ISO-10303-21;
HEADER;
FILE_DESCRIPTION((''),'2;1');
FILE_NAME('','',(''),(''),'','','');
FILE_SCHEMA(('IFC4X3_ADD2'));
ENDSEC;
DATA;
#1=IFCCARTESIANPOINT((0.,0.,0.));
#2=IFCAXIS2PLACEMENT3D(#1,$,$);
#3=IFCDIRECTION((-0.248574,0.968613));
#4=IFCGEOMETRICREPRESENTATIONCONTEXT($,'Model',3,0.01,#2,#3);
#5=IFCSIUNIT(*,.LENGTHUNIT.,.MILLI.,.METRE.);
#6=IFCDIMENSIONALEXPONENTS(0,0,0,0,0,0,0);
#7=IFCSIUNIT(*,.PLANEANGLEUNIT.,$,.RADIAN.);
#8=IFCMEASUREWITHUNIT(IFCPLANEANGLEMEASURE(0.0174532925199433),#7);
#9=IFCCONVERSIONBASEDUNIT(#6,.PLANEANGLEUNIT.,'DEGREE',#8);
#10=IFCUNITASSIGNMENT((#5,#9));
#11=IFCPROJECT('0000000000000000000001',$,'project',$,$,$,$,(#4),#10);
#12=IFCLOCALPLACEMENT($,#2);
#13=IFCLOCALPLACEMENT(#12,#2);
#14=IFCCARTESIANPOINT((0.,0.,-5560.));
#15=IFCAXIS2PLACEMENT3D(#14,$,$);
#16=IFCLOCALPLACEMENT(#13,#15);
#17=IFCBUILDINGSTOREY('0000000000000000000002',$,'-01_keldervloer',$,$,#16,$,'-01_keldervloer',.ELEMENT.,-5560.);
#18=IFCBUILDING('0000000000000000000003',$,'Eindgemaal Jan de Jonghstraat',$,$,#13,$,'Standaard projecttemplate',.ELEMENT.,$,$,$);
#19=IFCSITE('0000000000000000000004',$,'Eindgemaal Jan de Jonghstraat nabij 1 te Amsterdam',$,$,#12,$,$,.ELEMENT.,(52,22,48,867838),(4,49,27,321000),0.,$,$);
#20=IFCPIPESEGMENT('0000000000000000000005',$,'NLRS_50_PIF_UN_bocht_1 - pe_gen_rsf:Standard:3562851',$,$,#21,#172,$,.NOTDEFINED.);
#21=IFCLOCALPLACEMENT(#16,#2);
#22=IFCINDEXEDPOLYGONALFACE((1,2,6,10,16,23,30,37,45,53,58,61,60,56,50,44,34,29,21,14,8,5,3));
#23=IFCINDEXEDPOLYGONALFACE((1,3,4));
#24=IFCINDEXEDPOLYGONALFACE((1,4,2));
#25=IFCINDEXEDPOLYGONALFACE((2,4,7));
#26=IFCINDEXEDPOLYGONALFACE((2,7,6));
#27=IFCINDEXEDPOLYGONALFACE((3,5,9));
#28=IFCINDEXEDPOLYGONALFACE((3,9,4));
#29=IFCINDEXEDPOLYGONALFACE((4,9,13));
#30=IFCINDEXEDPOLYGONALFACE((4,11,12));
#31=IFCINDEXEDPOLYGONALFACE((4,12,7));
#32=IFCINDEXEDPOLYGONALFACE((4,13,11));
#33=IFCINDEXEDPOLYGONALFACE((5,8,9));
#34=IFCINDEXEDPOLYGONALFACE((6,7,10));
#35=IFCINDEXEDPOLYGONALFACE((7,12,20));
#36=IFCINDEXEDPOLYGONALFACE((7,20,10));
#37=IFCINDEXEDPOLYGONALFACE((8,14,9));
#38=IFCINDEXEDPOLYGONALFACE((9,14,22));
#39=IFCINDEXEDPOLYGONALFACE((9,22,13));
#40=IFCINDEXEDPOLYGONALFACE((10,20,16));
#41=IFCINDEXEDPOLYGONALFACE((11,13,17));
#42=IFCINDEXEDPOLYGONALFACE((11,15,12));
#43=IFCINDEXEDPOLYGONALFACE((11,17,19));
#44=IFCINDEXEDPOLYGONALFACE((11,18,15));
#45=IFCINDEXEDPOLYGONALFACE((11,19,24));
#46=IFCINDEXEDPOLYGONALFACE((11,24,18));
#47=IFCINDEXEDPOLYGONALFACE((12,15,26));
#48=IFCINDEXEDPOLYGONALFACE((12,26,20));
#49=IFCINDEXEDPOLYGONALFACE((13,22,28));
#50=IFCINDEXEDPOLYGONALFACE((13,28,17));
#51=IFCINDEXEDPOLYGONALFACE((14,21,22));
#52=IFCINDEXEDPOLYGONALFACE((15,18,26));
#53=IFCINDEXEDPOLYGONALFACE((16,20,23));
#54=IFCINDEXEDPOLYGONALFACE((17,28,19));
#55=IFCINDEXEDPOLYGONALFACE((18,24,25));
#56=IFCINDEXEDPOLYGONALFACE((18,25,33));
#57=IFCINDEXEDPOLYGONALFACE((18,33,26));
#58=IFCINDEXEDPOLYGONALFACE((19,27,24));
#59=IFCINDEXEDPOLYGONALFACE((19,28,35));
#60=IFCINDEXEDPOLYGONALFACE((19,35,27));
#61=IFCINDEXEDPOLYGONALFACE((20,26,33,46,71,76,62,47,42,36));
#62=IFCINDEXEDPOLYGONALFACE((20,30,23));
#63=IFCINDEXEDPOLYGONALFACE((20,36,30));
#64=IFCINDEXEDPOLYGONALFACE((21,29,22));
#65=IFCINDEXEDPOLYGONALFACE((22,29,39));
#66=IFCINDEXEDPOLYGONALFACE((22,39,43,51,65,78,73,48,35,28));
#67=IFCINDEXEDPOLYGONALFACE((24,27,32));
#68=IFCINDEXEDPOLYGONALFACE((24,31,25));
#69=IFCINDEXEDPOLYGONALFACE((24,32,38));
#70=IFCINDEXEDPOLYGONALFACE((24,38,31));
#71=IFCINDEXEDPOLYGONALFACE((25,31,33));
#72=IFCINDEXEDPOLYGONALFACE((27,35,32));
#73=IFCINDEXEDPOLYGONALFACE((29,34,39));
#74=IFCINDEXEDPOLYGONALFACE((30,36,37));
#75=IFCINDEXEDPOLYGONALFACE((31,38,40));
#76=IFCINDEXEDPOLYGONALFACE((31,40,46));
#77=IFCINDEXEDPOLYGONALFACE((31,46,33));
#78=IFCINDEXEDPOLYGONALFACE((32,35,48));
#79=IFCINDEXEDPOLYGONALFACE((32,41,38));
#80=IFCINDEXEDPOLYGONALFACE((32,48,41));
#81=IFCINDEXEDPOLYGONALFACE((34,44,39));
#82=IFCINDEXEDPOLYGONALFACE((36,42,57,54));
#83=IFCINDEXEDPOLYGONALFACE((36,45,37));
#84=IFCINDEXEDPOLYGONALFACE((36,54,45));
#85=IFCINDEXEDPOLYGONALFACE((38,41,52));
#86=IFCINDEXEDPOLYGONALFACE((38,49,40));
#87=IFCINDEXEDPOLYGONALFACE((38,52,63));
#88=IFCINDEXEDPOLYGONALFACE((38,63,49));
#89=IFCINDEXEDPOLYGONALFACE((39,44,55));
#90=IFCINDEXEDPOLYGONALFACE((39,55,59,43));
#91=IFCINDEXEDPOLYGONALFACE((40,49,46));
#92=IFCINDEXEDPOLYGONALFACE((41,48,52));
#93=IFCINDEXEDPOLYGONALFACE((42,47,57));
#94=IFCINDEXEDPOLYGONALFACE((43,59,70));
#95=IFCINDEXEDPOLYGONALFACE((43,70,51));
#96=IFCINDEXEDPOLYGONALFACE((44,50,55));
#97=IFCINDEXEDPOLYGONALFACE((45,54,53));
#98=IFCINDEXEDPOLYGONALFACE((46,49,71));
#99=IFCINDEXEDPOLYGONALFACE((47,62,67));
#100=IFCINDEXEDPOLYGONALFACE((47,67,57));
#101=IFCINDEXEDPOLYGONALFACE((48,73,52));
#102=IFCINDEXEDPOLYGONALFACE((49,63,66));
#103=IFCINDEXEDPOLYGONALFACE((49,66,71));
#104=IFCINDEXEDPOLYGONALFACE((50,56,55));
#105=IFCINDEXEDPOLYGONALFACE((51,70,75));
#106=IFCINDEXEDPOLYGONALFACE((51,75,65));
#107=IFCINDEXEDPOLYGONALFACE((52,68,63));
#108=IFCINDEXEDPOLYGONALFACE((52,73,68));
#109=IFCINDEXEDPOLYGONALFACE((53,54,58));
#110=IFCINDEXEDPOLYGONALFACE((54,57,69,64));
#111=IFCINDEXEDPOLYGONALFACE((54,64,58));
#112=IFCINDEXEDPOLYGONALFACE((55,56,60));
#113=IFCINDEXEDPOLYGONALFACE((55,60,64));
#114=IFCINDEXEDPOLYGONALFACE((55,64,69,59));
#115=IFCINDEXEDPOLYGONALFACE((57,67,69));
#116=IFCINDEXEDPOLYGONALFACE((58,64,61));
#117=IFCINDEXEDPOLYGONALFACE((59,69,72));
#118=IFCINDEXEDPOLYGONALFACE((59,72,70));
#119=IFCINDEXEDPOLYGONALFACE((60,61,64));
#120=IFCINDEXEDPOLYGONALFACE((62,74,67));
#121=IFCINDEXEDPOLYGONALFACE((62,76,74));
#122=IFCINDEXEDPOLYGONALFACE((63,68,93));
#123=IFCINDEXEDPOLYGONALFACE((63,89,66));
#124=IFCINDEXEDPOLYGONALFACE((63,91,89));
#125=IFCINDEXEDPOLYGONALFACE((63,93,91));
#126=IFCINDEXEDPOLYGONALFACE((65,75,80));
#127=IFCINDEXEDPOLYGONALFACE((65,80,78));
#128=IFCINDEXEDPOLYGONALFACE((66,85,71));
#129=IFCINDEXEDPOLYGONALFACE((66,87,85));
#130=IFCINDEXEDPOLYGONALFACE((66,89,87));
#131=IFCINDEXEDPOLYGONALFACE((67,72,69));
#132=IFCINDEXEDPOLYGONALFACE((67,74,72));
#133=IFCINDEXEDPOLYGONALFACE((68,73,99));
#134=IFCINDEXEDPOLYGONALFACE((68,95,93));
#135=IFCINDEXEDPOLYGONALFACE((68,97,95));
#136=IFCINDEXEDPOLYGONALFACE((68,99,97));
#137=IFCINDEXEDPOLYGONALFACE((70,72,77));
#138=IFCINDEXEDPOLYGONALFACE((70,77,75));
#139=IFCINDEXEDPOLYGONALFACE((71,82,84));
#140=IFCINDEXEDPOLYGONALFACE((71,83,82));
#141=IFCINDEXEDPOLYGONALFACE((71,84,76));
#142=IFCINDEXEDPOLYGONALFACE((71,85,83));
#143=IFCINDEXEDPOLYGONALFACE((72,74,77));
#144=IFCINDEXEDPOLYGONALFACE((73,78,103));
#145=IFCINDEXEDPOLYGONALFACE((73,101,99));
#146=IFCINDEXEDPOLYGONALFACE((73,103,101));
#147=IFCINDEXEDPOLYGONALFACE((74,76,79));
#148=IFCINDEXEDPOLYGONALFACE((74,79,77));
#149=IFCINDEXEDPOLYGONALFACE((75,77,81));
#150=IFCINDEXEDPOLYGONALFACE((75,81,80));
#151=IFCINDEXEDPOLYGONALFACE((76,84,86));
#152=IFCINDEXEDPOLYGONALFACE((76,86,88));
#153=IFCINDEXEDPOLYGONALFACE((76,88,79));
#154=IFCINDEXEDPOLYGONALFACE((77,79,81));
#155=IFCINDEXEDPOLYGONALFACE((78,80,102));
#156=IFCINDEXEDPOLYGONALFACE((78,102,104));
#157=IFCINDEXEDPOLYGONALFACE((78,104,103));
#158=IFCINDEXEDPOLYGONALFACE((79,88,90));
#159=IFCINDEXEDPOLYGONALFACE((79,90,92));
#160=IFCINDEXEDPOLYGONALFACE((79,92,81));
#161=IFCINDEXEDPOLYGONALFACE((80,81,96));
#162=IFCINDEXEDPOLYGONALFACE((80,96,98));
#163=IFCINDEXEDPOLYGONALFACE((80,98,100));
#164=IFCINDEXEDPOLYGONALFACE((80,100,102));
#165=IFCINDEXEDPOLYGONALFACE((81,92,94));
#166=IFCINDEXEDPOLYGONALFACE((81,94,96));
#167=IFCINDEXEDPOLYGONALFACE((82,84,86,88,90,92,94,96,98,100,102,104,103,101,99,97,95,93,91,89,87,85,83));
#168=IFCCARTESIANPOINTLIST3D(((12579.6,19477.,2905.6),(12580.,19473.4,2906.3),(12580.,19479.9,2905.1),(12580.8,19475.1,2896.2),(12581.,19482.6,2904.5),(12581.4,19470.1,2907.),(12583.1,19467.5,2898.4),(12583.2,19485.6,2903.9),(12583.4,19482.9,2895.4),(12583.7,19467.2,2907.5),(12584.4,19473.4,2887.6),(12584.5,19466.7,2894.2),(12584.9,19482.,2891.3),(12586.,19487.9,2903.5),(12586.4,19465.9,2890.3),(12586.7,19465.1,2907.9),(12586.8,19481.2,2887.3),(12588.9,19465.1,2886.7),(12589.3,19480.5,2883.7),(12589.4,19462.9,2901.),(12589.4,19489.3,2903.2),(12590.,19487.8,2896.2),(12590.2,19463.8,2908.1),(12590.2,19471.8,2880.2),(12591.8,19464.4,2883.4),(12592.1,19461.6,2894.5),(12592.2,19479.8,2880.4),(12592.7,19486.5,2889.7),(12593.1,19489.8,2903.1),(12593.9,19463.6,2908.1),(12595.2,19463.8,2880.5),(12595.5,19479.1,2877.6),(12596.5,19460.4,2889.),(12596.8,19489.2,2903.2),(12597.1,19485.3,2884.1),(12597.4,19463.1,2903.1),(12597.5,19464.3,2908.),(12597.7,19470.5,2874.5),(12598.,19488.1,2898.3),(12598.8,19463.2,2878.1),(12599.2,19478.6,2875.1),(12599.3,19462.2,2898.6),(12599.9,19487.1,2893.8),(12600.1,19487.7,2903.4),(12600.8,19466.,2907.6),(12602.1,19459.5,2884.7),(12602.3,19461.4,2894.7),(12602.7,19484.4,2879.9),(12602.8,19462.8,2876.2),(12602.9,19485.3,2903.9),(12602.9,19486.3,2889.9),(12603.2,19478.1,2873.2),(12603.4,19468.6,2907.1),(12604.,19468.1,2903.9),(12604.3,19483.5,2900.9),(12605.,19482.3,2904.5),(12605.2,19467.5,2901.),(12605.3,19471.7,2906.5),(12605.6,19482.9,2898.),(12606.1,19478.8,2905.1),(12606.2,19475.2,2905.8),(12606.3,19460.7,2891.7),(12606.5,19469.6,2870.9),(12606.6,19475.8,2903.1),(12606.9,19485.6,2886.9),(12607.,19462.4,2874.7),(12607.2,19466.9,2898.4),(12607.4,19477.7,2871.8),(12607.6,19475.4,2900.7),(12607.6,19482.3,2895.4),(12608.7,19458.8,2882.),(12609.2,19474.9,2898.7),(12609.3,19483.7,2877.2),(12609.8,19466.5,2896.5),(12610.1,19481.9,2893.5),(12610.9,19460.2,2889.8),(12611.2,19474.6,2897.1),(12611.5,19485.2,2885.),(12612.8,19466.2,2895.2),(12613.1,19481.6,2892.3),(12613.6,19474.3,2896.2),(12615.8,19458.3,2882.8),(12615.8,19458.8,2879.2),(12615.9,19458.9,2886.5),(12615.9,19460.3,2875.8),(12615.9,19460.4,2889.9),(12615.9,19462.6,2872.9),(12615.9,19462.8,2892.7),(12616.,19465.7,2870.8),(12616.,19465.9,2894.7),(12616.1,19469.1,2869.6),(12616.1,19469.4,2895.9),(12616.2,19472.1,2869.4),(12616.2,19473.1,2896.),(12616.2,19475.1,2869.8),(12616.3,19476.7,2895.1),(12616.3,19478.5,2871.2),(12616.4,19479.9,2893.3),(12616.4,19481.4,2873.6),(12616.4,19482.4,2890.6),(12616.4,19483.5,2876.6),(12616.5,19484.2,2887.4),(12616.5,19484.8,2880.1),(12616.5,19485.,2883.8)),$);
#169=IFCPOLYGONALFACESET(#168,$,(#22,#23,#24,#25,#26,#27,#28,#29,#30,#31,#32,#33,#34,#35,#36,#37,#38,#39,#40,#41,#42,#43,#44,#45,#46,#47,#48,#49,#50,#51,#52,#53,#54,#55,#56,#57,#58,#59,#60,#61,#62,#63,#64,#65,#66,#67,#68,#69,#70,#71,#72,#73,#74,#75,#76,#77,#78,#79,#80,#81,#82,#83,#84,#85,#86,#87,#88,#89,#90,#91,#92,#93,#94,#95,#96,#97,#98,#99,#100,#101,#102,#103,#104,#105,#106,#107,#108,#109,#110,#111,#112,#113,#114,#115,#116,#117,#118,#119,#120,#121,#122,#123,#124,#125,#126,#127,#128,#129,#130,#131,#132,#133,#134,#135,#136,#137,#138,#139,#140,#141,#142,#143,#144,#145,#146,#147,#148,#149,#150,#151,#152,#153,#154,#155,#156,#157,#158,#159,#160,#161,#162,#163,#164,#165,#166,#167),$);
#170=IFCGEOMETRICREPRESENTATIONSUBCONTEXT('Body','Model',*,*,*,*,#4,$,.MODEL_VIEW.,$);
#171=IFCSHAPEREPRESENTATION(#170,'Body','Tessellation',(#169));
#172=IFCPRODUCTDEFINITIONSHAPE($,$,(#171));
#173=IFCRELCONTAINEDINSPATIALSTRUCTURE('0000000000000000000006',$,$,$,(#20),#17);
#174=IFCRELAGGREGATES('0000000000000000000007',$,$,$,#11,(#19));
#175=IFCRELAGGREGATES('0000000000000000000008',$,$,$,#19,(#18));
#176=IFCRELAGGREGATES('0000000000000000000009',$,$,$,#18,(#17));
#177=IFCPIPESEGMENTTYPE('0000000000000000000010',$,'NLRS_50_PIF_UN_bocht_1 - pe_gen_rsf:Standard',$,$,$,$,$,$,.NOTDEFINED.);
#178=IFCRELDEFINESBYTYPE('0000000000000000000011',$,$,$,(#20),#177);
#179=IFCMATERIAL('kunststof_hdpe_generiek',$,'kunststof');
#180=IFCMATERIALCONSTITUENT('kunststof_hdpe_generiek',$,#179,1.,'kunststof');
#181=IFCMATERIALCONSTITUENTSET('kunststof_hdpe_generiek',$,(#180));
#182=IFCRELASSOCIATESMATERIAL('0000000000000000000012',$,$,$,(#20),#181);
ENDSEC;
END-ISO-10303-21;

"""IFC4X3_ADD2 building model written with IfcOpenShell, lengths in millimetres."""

from ifc_helpers import new_model, entity, si_unit, converted_unit, direction, frame, origin, place, context, subcontext, project, spatial, source, transform, mapped, material, constituent, constituent_set, type_object, type_shapes, element, save


model = new_model("IFC4X3_ADD2")

# Units and contexts
model_context = context("Model", 3, precision=0.01, world=origin(), true_north=direction((-0.248574, 0.968613)))
body_context = subcontext(model_context, "Body", "Model", "MODEL_VIEW")
ifc_project = project(units=[si_unit("LENGTHUNIT", "METRE", prefix="MILLI"), converted_unit("PLANEANGLEUNIT", "DEGREE", entity("IfcPlaneAngleMeasure", 0.0174532925199433), si_unit("PLANEANGLEUNIT", "RADIAN"), dimensions=[0, 0, 0, 0, 0, 0, 0])], contexts=[model_context])

# Site, building, storey
site_placement = place(None, origin())
site = spatial("IfcSite", under=ifc_project, at=site_placement, Name="Eindgemaal Jan de Jonghstraat nabij 1 te Amsterdam", CompositionType="ELEMENT", RefLatitude=(52, 22, 48, 867838), RefLongitude=(4, 49, 27, 321000), RefElevation=0.0)
building_placement = place(site_placement, origin())
building = spatial("IfcBuilding", under=site, at=building_placement, Name="Eindgemaal Jan de Jonghstraat", LongName="Standaard projecttemplate", CompositionType="ELEMENT")
storey_placement = place(building_placement, frame((0.0, 0.0, -5560.0)))
storey = spatial("IfcBuildingStorey", under=building, at=storey_placement, Name="-01_keldervloer", LongName="-01_keldervloer", CompositionType="ELEMENT", Elevation=-5560.0)

# Pipe segment
ifc_material_1 = material(Name="kunststof_hdpe_generiek", Category="kunststof")
ifc_constituent_1 = constituent(ifc_material_1, Name="kunststof_hdpe_generiek", Category="kunststof", fraction=1.0)
ifc_constituent_set_1 = constituent_set(constituents=[ifc_constituent_1], Name="kunststof_hdpe_generiek")
pipe_segment_type_1 = type_object("IfcPipeSegmentType", Name="NLRS_50_PIF_UN_bocht_1 - pe_gen_rsf:Standard", PredefinedType="NOTDEFINED")
trimmed_curve_1 = entity("IfcTrimmedCurve", entity("IfcCircle", entity("IfcAxis2Placement2D", entity("IfcCartesianPoint", [-10.0, 0.0]), entity("IfcDirection", [0.004573, 0.99999])), 10.0), [entity("IfcParameterValue", 270.262008)], [entity("IfcParameterValue", 0.0)], True, "PARAMETER")
shared_shape_1 = source(origin(), body_context, "Body", "AdvancedSweptSolid", [
    entity("IfcSurfaceCurveSweptAreaSolid", entity("IfcCircleProfileDef", "AREA", None, entity("IfcAxis2Placement2D", entity("IfcCartesianPoint", [13.3, 0.0]), entity("IfcDirection", [1.0, 0.0])), 13.3), entity("IfcAxis2Placement3D", entity("IfcCartesianPoint", [-13.2, 23.3, 0.0]), entity("IfcDirection", [0.0, 0.0, -1.0]), entity("IfcDirection", [0.99999, -0.004573, 0.0])), trimmed_curve_1, entity("IfcParameterValue", 0.0), entity("IfcParameterValue", 89.737992), entity("IfcSurfaceOfLinearExtrusion", entity("IfcArbitraryOpenProfileDef", "CURVE", None, trimmed_curve_1), entity("IfcAxis2Placement3D", entity("IfcCartesianPoint", [0.0, 0.0, -304.8])), entity("IfcDirection", [0.0, 0.0, 1.0]), 1.0)),
])
type_shapes(pipe_segment_type_1, [shared_shape_1])
pipe_segment_1_placement = place(storey_placement, frame((12592.9, 19472.2, 2882.7), z_axis=(-0.0236, -0.981466, 0.19018), x_axis=(0.0, -0.190233, -0.981739)))
element("IfcPipeSegment", 1, at=pipe_segment_1_placement, inside=storey, type_object=pipe_segment_type_1, material=ifc_constituent_set_1, Name="NLRS_50_PIF_UN_bocht_1 - pe_gen_rsf:Standard:3562851", PredefinedType="NOTDEFINED", context=body_context, shape_type="MappedRepresentation", body=[
    mapped(shared_shape_1, transform((0.0, 0.0, 0.0), scale=1.0)),
])

save(model, "model.ifc")
